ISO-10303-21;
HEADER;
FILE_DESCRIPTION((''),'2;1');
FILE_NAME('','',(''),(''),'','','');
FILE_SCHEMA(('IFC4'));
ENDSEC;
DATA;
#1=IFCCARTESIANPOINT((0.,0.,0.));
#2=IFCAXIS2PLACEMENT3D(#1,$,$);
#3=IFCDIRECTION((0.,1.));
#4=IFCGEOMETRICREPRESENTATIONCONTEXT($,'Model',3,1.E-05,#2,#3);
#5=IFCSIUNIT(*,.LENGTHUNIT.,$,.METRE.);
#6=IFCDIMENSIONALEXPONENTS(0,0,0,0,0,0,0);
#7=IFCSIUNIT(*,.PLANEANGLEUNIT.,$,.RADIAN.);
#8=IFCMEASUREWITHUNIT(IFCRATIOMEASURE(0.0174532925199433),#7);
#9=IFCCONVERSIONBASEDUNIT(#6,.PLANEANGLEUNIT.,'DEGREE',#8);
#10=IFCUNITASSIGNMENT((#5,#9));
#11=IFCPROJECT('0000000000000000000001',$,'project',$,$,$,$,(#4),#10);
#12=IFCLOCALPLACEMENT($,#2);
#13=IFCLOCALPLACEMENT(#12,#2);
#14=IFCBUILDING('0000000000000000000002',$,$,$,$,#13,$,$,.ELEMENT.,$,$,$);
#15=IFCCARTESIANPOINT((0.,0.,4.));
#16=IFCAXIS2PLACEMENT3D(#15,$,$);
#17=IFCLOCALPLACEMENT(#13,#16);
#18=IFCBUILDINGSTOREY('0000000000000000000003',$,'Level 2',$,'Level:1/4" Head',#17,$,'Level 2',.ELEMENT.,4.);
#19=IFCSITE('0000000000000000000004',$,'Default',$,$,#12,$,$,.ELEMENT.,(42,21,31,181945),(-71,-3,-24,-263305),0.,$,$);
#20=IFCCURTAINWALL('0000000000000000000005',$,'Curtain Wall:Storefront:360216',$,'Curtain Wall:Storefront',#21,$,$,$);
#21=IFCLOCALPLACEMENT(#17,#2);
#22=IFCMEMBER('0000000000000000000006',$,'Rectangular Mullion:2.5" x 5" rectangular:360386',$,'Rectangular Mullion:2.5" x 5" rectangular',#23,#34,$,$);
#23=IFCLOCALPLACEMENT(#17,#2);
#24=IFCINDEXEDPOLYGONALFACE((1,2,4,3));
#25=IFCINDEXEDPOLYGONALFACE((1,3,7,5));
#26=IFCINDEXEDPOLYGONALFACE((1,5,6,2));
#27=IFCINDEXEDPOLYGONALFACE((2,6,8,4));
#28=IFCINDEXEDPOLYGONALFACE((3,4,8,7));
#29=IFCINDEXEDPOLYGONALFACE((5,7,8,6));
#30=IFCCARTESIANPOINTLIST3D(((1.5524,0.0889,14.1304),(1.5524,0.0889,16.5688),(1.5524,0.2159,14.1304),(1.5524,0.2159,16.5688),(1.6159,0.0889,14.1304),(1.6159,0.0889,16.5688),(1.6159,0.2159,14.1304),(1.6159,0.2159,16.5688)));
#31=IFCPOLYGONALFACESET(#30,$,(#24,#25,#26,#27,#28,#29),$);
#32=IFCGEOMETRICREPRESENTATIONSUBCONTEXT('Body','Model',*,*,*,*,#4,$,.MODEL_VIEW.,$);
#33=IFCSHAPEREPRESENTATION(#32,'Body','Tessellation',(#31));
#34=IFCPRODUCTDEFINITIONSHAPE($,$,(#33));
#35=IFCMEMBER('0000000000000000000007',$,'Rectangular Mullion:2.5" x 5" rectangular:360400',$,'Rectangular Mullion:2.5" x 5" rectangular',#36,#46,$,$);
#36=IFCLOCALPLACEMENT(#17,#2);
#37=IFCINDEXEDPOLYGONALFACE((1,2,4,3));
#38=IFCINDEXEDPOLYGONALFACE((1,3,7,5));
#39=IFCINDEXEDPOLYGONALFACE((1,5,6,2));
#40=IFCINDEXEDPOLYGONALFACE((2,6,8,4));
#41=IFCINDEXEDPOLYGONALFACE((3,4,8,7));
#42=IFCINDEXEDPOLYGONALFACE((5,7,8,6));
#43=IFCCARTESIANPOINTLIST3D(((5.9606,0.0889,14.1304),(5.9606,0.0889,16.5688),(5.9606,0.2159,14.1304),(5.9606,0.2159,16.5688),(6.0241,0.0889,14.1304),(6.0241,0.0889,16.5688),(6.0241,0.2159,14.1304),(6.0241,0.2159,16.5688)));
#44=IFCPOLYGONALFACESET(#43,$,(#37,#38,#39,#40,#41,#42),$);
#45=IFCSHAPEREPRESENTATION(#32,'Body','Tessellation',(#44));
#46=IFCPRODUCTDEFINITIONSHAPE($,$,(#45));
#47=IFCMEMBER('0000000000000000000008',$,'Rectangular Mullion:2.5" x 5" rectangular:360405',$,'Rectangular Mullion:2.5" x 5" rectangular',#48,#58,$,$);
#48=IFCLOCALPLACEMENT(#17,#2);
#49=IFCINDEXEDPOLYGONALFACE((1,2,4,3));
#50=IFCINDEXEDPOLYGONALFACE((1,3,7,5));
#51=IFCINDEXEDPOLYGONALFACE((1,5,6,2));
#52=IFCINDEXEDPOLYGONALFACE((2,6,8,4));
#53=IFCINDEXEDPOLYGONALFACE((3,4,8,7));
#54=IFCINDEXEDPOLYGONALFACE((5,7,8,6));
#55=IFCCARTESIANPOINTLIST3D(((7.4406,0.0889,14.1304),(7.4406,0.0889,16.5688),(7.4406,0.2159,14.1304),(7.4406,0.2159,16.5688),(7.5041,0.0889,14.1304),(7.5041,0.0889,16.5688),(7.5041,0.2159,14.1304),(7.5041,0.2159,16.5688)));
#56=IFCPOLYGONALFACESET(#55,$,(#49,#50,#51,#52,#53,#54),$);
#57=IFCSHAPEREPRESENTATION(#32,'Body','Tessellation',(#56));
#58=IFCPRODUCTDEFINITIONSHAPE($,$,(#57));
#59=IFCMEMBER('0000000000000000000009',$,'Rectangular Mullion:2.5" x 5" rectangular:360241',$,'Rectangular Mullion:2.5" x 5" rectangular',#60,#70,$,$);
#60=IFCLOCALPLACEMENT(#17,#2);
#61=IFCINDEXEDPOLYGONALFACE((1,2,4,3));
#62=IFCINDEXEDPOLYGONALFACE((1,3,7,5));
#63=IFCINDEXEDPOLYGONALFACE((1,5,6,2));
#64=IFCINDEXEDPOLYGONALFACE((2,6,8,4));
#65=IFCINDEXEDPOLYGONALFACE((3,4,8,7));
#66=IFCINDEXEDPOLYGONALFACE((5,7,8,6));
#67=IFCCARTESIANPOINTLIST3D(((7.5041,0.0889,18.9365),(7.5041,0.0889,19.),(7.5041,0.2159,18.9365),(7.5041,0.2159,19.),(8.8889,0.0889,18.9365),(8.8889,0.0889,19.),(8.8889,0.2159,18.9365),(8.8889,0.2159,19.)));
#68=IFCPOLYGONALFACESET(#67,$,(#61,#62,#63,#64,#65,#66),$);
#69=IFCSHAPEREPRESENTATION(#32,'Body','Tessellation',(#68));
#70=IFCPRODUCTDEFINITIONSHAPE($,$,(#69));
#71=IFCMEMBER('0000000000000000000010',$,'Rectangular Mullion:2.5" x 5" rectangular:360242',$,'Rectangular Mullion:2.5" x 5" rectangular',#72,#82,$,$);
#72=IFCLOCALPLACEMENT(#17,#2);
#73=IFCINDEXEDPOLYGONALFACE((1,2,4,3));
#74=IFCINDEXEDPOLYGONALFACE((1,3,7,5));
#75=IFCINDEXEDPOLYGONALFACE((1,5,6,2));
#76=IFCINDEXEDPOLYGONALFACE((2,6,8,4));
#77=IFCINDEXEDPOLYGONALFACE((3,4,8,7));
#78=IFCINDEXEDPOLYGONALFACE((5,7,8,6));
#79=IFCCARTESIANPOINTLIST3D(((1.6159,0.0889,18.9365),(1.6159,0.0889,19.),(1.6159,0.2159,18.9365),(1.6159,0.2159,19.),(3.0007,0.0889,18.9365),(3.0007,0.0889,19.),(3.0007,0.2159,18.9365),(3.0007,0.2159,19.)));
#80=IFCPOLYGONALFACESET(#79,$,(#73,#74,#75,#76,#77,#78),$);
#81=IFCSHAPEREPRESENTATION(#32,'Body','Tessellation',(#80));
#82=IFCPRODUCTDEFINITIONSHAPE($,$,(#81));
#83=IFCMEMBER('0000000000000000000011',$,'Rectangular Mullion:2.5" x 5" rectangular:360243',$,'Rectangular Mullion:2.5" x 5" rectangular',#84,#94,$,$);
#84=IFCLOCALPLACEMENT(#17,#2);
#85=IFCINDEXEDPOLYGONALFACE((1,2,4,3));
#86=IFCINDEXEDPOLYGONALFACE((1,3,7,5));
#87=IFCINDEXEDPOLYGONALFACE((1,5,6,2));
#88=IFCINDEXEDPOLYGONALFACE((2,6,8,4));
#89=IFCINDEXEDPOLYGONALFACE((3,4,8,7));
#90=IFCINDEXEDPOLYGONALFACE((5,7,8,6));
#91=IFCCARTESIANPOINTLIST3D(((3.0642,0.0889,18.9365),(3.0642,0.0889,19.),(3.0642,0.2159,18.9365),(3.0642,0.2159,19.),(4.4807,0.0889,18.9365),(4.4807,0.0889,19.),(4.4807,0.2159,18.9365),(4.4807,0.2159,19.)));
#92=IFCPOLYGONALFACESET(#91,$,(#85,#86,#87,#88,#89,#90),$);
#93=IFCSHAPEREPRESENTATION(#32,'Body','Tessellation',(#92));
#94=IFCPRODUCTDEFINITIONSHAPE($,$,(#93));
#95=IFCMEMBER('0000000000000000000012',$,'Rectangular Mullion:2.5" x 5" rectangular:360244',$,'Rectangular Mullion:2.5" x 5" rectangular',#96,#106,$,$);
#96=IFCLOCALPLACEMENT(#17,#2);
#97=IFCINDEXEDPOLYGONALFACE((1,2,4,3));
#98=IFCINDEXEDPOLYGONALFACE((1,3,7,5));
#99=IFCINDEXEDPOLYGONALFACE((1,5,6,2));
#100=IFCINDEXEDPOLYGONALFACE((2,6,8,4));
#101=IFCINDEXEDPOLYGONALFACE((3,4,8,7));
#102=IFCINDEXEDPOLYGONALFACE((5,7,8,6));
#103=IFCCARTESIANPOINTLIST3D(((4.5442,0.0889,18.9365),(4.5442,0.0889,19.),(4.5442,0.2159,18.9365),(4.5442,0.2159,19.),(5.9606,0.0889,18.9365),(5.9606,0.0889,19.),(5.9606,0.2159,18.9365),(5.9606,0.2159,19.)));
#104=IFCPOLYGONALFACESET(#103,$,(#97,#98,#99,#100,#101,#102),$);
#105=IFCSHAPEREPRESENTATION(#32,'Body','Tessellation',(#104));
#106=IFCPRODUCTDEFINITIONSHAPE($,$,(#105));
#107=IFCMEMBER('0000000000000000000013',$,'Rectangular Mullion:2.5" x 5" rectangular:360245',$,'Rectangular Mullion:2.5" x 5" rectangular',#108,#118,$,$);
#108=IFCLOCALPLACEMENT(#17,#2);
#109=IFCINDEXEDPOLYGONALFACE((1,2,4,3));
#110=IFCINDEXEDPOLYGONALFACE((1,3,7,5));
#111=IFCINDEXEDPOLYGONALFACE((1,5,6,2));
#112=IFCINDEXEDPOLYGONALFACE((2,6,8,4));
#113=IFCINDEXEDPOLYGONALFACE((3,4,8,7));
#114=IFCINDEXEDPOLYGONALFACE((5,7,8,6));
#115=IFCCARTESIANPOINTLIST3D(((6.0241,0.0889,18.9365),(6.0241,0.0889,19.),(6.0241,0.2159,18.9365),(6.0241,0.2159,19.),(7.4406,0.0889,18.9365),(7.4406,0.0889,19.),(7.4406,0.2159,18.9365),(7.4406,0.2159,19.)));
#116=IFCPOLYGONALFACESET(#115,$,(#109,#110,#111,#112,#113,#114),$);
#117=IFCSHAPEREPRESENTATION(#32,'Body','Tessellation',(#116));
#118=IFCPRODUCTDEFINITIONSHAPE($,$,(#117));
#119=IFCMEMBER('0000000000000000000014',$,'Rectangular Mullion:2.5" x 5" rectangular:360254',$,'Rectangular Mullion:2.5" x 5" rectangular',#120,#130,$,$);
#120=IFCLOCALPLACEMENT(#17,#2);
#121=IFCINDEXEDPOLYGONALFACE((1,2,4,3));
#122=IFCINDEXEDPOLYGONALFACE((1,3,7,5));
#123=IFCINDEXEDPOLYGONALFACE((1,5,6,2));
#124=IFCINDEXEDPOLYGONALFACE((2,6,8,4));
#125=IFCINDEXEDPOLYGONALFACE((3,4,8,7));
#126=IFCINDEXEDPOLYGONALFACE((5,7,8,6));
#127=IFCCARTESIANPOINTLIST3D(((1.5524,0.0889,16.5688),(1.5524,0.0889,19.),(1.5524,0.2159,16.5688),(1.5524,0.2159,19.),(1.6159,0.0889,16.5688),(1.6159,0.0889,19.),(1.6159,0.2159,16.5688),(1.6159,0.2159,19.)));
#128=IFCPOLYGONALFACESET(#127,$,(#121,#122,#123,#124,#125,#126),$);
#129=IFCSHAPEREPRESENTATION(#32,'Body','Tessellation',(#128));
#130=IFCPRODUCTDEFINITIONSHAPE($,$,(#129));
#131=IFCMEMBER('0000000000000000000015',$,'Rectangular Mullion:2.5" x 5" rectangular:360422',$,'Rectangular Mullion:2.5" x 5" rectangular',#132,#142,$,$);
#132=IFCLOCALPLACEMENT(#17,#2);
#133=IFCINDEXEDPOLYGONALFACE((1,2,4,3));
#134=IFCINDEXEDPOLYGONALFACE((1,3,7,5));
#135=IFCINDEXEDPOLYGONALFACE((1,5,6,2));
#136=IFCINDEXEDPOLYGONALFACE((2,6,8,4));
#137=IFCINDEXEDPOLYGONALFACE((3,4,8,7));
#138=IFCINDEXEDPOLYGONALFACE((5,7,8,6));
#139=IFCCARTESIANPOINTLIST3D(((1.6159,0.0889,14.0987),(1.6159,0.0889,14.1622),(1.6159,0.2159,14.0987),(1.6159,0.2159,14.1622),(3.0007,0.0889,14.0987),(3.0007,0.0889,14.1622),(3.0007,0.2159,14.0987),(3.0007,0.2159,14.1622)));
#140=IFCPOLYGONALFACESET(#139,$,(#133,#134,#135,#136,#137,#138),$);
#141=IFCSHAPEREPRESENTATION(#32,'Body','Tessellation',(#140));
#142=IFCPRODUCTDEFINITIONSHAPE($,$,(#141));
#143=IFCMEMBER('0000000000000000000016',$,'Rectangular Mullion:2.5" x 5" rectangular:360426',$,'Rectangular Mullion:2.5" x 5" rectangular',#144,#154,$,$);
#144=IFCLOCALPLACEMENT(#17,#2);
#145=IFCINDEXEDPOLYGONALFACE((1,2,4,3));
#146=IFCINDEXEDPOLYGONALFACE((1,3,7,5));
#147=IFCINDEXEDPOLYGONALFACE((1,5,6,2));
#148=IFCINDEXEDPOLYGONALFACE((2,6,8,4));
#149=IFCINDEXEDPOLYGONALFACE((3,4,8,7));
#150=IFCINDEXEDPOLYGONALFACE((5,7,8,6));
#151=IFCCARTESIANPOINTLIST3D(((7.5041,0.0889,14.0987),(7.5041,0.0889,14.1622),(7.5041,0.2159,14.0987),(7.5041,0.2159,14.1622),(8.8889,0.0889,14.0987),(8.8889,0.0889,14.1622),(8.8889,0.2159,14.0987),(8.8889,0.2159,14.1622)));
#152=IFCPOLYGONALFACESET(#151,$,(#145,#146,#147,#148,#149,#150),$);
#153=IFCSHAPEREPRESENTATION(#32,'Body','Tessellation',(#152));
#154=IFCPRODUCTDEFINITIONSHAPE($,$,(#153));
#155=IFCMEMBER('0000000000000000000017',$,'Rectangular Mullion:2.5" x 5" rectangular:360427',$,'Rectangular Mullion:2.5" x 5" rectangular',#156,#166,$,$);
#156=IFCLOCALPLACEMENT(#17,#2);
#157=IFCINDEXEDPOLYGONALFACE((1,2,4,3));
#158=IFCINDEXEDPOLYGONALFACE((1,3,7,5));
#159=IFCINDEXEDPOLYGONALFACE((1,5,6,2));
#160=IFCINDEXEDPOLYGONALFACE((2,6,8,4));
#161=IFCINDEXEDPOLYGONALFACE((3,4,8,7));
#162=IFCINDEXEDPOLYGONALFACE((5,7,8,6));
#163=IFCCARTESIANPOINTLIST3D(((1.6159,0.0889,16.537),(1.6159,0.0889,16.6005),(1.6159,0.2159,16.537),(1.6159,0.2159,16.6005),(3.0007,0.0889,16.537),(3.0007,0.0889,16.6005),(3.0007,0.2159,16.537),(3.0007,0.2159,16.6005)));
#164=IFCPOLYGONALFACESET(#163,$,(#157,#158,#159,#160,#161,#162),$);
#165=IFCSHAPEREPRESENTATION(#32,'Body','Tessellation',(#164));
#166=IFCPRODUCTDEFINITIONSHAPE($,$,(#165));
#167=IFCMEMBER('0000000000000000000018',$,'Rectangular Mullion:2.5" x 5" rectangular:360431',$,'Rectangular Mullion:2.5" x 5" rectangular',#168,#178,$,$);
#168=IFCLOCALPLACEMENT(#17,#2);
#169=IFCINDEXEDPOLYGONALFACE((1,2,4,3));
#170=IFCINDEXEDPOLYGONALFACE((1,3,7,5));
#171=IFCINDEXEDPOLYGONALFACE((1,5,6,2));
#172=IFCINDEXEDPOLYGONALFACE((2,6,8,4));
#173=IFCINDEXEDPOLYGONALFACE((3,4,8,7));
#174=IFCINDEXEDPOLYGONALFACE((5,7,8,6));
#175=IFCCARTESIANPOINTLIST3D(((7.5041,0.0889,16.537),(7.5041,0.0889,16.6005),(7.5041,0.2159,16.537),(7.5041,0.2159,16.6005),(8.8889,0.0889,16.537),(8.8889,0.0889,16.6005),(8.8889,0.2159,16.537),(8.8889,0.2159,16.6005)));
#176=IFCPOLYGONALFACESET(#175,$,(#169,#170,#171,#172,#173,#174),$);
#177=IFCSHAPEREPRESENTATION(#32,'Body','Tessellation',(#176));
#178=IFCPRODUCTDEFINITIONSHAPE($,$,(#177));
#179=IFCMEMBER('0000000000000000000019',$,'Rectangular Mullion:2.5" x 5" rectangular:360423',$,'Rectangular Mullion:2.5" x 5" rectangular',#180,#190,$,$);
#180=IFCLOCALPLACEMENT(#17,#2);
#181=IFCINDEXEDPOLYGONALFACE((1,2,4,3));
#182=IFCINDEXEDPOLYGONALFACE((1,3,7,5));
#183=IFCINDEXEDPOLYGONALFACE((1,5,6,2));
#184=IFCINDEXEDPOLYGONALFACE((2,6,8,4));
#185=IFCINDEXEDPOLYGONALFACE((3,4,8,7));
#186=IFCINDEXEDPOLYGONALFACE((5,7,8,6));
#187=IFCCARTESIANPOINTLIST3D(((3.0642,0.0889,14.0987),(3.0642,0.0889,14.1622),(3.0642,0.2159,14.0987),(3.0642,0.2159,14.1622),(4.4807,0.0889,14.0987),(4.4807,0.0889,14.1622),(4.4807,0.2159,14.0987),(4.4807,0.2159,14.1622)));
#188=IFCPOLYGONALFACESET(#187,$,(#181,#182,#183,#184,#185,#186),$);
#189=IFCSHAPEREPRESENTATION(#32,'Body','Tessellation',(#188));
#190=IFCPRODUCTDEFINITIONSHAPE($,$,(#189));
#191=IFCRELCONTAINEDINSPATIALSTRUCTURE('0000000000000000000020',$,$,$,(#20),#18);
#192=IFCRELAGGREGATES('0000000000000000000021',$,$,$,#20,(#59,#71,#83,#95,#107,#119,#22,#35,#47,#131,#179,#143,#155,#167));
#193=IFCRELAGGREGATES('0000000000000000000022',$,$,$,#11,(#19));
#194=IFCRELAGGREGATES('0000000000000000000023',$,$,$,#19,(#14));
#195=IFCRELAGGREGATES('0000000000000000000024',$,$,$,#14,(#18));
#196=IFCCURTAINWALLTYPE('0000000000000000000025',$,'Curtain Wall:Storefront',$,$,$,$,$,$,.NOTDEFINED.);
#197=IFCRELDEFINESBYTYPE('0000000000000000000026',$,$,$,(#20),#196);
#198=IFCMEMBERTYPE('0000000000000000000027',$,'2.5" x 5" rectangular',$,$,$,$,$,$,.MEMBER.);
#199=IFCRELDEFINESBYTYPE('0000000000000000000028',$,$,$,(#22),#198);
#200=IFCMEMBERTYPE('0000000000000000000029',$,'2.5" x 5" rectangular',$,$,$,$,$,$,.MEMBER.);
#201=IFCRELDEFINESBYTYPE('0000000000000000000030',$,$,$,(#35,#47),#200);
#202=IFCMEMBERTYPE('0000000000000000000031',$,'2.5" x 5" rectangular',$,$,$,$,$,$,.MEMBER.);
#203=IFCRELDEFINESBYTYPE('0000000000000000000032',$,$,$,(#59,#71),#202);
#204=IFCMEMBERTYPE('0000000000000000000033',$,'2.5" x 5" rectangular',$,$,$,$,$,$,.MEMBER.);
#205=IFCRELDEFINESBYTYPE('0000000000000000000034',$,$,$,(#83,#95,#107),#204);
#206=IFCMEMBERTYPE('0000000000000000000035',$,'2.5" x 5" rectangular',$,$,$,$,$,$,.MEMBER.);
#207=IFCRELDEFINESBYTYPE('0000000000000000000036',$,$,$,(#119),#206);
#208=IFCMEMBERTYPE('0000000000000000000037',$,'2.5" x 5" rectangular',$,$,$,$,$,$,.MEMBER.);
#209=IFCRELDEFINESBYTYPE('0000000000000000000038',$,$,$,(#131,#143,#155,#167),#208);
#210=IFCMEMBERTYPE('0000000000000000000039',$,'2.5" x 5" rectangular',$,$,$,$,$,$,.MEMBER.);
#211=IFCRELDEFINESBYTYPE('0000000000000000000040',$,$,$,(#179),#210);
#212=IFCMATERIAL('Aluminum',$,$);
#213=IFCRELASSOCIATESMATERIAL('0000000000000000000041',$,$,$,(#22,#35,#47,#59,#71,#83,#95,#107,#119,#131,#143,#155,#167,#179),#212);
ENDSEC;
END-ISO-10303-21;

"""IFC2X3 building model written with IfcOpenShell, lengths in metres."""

from ifc_helpers import new_model, entity, si_unit, converted_unit, direction, frame, origin, origin_2d_with_axis, place, context, subcontext, project, spatial, rectangle, extrude, source, transform, mapped, material, type_object, type_shapes, element, aggregate, save


model = new_model("IFC2X3")

# Units and contexts
model_context = context("Model", 3, precision=1e-05, world=origin(), true_north=direction((0.0, 1.0)))
body_context = subcontext(model_context, "Body", "Model", "MODEL_VIEW")
ifc_project = project(units=[si_unit("LENGTHUNIT", "METRE"), converted_unit("PLANEANGLEUNIT", "DEGREE", entity("IfcRatioMeasure", 0.0174532925199433), si_unit("PLANEANGLEUNIT", "RADIAN"), dimensions=[0, 0, 0, 0, 0, 0, 0])], contexts=[model_context])

# Site, building, storey
site_placement = place(None, origin())
site = spatial("IfcSite", under=ifc_project, at=site_placement, Name="Default", CompositionType="ELEMENT", RefLatitude=(42, 21, 31, 181945), RefLongitude=(-71, -3, -24, -263305), RefElevation=0.0)
building_placement = place(site_placement, origin())
building = spatial("IfcBuilding", under=site, at=building_placement, CompositionType="ELEMENT")
storey_placement = place(building_placement, frame((0.0, 0.0, 4.0)))
storey = spatial("IfcBuildingStorey", under=building, at=storey_placement, Name="Level 2", ObjectType="Level:1/4\" Head", LongName="Level 2", CompositionType="ELEMENT", Elevation=4.0)

# Curtain wall, members
curtain_wall_type = type_object("IfcCurtainWallType", Name="Curtain Wall:Storefront", PredefinedType="NOTDEFINED")
curtain_wall_placement = place(storey_placement, frame((0.0, 0.0, -4.0)))
curtain_wall = element("IfcCurtainWall", 1, at=curtain_wall_placement, inside=storey, type_object=curtain_wall_type, Name="Curtain Wall:Storefront:360216", ObjectType="Curtain Wall:Storefront")
ifc_material_1 = material(Name="Aluminum")
member_type_1 = type_object("IfcMemberType", Name="2.5\" x 5\" rectangular", PredefinedType="MEMBER")
shared_shape_1 = source(origin(), body_context, "Body", "SweptSolid", [
    extrude(rectangle(XDim=0.127, YDim=0.0635, at=origin_2d_with_axis()), frame((-0.0318, 0.0, -2.4384), z_axis=(0.0, 0.0, 1.0), x_axis=(0.0, -1.0, 0.0)), (0.0, 0.0, 1.0), 2.4384),
])
type_shapes(member_type_1, [shared_shape_1])
member_1_placement = place(storey_placement, frame((1.5524, 0.1524, 16.5688), z_axis=(0.0, 0.0, 1.0), x_axis=(-1.0, 0.0, 0.0)))
member_1 = element("IfcMember", 2, at=member_1_placement, type_object=member_type_1, material=ifc_material_1, Name="Rectangular Mullion:2.5\" x 5\" rectangular:360386", ObjectType="Rectangular Mullion:2.5\" x 5\" rectangular", context=body_context, shape_type="MappedRepresentation", body=[
    mapped(shared_shape_1, transform((0.0, 0.0, 0.0), scale=1.0)),
])
member_type_2 = type_object("IfcMemberType", Name="2.5\" x 5\" rectangular", PredefinedType="MEMBER")
shared_shape_2 = source(origin(), body_context, "Body", "SweptSolid", [
    extrude(rectangle(XDim=0.127, YDim=0.0635, at=origin_2d_with_axis()), frame((0.0, 0.0, -2.4384), z_axis=(0.0, 0.0, 1.0), x_axis=(0.0, -1.0, 0.0)), (0.0, 0.0, 1.0), 2.4384),
])
type_shapes(member_type_2, [shared_shape_2])
member_2_placement = place(storey_placement, frame((5.9924, 0.1524, 14.1304), z_axis=(0.0, 0.0, -1.0), x_axis=(1.0, 0.0, 0.0)))
member_2 = element("IfcMember", 3, at=member_2_placement, type_object=member_type_2, material=ifc_material_1, Name="Rectangular Mullion:2.5\" x 5\" rectangular:360400", ObjectType="Rectangular Mullion:2.5\" x 5\" rectangular", context=body_context, shape_type="MappedRepresentation", body=[
    mapped(shared_shape_2, transform((0.0, 0.0, 0.0), scale=1.0)),
])
member_3_placement = place(storey_placement, frame((7.4724, 0.1524, 14.1304), z_axis=(0.0, 0.0, -1.0), x_axis=(1.0, 0.0, 0.0)))
member_3 = element("IfcMember", 4, at=member_3_placement, type_object=member_type_2, material=ifc_material_1, Name="Rectangular Mullion:2.5\" x 5\" rectangular:360405", ObjectType="Rectangular Mullion:2.5\" x 5\" rectangular", context=body_context, shape_type="MappedRepresentation", body=[
    mapped(shared_shape_2, transform((0.0, 0.0, 0.0), scale=1.0)),
])
member_type_3 = type_object("IfcMemberType", Name="2.5\" x 5\" rectangular", PredefinedType="MEMBER")
shared_shape_3 = source(origin(), body_context, "Body", "SweptSolid", [
    extrude(rectangle(XDim=0.127, YDim=0.0635, at=origin_2d_with_axis()), frame((-0.0318, 0.0, -1.3848), z_axis=(0.0, 0.0, 1.0), x_axis=(0.0, -1.0, 0.0)), (0.0, 0.0, 1.0), 1.3848),
])
type_shapes(member_type_3, [shared_shape_3])
member_4_placement = place(storey_placement, frame((8.8889, 0.1524, 19.0), z_axis=(1.0, 0.0, 0.0), x_axis=(0.0, 0.0, 1.0)))
member_4 = element("IfcMember", 5, at=member_4_placement, type_object=member_type_3, material=ifc_material_1, Name="Rectangular Mullion:2.5\" x 5\" rectangular:360241", ObjectType="Rectangular Mullion:2.5\" x 5\" rectangular", context=body_context, shape_type="MappedRepresentation", body=[
    mapped(shared_shape_3, transform((0.0, 0.0, 0.0), scale=1.0)),
])
member_5_placement = place(storey_placement, frame((3.0007, 0.1524, 19.0), z_axis=(1.0, 0.0, 0.0), x_axis=(0.0, 0.0, 1.0)))
member_5 = element("IfcMember", 6, at=member_5_placement, type_object=member_type_3, material=ifc_material_1, Name="Rectangular Mullion:2.5\" x 5\" rectangular:360242", ObjectType="Rectangular Mullion:2.5\" x 5\" rectangular", context=body_context, shape_type="MappedRepresentation", body=[
    mapped(shared_shape_3, transform((0.0, 0.0, 0.0), scale=1.0)),
])
member_type_4 = type_object("IfcMemberType", Name="2.5\" x 5\" rectangular", PredefinedType="MEMBER")
shared_shape_4 = source(origin(), body_context, "Body", "SweptSolid", [
    extrude(rectangle(XDim=0.127, YDim=0.0635, at=origin_2d_with_axis()), frame((-0.0318, 0.0, -1.4165), z_axis=(0.0, 0.0, 1.0), x_axis=(0.0, -1.0, 0.0)), (0.0, 0.0, 1.0), 1.4165),
])
type_shapes(member_type_4, [shared_shape_4])
member_6_placement = place(storey_placement, frame((4.4807, 0.1524, 19.0), z_axis=(1.0, 0.0, 0.0), x_axis=(0.0, 0.0, 1.0)))
member_6 = element("IfcMember", 7, at=member_6_placement, type_object=member_type_4, material=ifc_material_1, Name="Rectangular Mullion:2.5\" x 5\" rectangular:360243", ObjectType="Rectangular Mullion:2.5\" x 5\" rectangular", context=body_context, shape_type="MappedRepresentation", body=[
    mapped(shared_shape_4, transform((0.0, 0.0, 0.0), scale=1.0)),
])
member_7_placement = place(storey_placement, frame((5.9606, 0.1524, 19.0), z_axis=(1.0, 0.0, 0.0), x_axis=(0.0, 0.0, 1.0)))
member_7 = element("IfcMember", 8, at=member_7_placement, type_object=member_type_4, material=ifc_material_1, Name="Rectangular Mullion:2.5\" x 5\" rectangular:360244", ObjectType="Rectangular Mullion:2.5\" x 5\" rectangular", context=body_context, shape_type="MappedRepresentation", body=[
    mapped(shared_shape_4, transform((0.0, 0.0, 0.0), scale=1.0)),
])
member_8_placement = place(storey_placement, frame((7.4406, 0.1524, 19.0), z_axis=(1.0, 0.0, 0.0), x_axis=(0.0, 0.0, 1.0)))
member_8 = element("IfcMember", 9, at=member_8_placement, type_object=member_type_4, material=ifc_material_1, Name="Rectangular Mullion:2.5\" x 5\" rectangular:360245", ObjectType="Rectangular Mullion:2.5\" x 5\" rectangular", context=body_context, shape_type="MappedRepresentation", body=[
    mapped(shared_shape_4, transform((0.0, 0.0, 0.0), scale=1.0)),
])
member_type_5 = type_object("IfcMemberType", Name="2.5\" x 5\" rectangular", PredefinedType="MEMBER")
shared_shape_5 = source(origin(), body_context, "Body", "SweptSolid", [
    extrude(rectangle(XDim=0.127, YDim=0.0635, at=origin_2d_with_axis()), frame((-0.0318, 0.0, -2.4312), z_axis=(0.0, 0.0, 1.0), x_axis=(0.0, -1.0, 0.0)), (0.0, 0.0, 1.0), 2.4312),
])
type_shapes(member_type_5, [shared_shape_5])
member_9_placement = place(storey_placement, frame((1.5524, 0.1524, 19.0), z_axis=(0.0, 0.0, 1.0), x_axis=(-1.0, 0.0, 0.0)))
member_9 = element("IfcMember", 10, at=member_9_placement, type_object=member_type_5, material=ifc_material_1, Name="Rectangular Mullion:2.5\" x 5\" rectangular:360254", ObjectType="Rectangular Mullion:2.5\" x 5\" rectangular", context=body_context, shape_type="MappedRepresentation", body=[
    mapped(shared_shape_5, transform((0.0, 0.0, 0.0), scale=1.0)),
])
member_type_6 = type_object("IfcMemberType", Name="2.5\" x 5\" rectangular", PredefinedType="MEMBER")
shared_shape_6 = source(origin(), body_context, "Body", "SweptSolid", [
    extrude(rectangle(XDim=0.127, YDim=0.0635, at=origin_2d_with_axis()), frame((0.0, 0.0, -1.3848), z_axis=(0.0, 0.0, 1.0), x_axis=(0.0, -1.0, 0.0)), (0.0, 0.0, 1.0), 1.3848),
])
type_shapes(member_type_6, [shared_shape_6])
member_10_placement = place(storey_placement, frame((3.0007, 0.1524, 14.1304), z_axis=(1.0, 0.0, 0.0), x_axis=(0.0, 0.0, 1.0)))
member_10 = element("IfcMember", 11, at=member_10_placement, type_object=member_type_6, material=ifc_material_1, Name="Rectangular Mullion:2.5\" x 5\" rectangular:360422", ObjectType="Rectangular Mullion:2.5\" x 5\" rectangular", context=body_context, shape_type="MappedRepresentation", body=[
    mapped(shared_shape_6, transform((0.0, 0.0, 0.0), scale=1.0)),
])
member_11_placement = place(storey_placement, frame((8.8889, 0.1524, 14.1304), z_axis=(1.0, 0.0, 0.0), x_axis=(0.0, 0.0, 1.0)))
member_11 = element("IfcMember", 12, at=member_11_placement, type_object=member_type_6, material=ifc_material_1, Name="Rectangular Mullion:2.5\" x 5\" rectangular:360426", ObjectType="Rectangular Mullion:2.5\" x 5\" rectangular", context=body_context, shape_type="MappedRepresentation", body=[
    mapped(shared_shape_6, transform((0.0, 0.0, 0.0), scale=1.0)),
])
member_12_placement = place(storey_placement, frame((3.0007, 0.1524, 16.5688), z_axis=(1.0, 0.0, 0.0), x_axis=(0.0, 0.0, 1.0)))
member_12 = element("IfcMember", 13, at=member_12_placement, type_object=member_type_6, material=ifc_material_1, Name="Rectangular Mullion:2.5\" x 5\" rectangular:360427", ObjectType="Rectangular Mullion:2.5\" x 5\" rectangular", context=body_context, shape_type="MappedRepresentation", body=[
    mapped(shared_shape_6, transform((0.0, 0.0, 0.0), scale=1.0)),
])
member_13_placement = place(storey_placement, frame((8.8889, 0.1524, 16.5688), z_axis=(1.0, 0.0, 0.0), x_axis=(0.0, 0.0, 1.0)))
member_13 = element("IfcMember", 14, at=member_13_placement, type_object=member_type_6, material=ifc_material_1, Name="Rectangular Mullion:2.5\" x 5\" rectangular:360431", ObjectType="Rectangular Mullion:2.5\" x 5\" rectangular", context=body_context, shape_type="MappedRepresentation", body=[
    mapped(shared_shape_6, transform((0.0, 0.0, 0.0), scale=1.0)),
])
member_type_7 = type_object("IfcMemberType", Name="2.5\" x 5\" rectangular", PredefinedType="MEMBER")
shared_shape_7 = source(origin(), body_context, "Body", "SweptSolid", [
    extrude(rectangle(XDim=0.127, YDim=0.0635, at=origin_2d_with_axis()), frame((0.0, 0.0, -1.4165), z_axis=(0.0, 0.0, 1.0), x_axis=(0.0, -1.0, 0.0)), (0.0, 0.0, 1.0), 1.4165),
])
type_shapes(member_type_7, [shared_shape_7])
member_14_placement = place(storey_placement, frame((4.4807, 0.1524, 14.1304), z_axis=(1.0, 0.0, 0.0), x_axis=(0.0, 0.0, 1.0)))
member_14 = element("IfcMember", 15, at=member_14_placement, type_object=member_type_7, material=ifc_material_1, Name="Rectangular Mullion:2.5\" x 5\" rectangular:360423", ObjectType="Rectangular Mullion:2.5\" x 5\" rectangular", context=body_context, shape_type="MappedRepresentation", body=[
    mapped(shared_shape_7, transform((0.0, 0.0, 0.0), scale=1.0)),
])
aggregate(curtain_wall, [member_4, member_5, member_6, member_7, member_8, member_9, member_1, member_2, member_3, member_10, member_14, member_11, member_12, member_13])

save(model, "model.ifc")
